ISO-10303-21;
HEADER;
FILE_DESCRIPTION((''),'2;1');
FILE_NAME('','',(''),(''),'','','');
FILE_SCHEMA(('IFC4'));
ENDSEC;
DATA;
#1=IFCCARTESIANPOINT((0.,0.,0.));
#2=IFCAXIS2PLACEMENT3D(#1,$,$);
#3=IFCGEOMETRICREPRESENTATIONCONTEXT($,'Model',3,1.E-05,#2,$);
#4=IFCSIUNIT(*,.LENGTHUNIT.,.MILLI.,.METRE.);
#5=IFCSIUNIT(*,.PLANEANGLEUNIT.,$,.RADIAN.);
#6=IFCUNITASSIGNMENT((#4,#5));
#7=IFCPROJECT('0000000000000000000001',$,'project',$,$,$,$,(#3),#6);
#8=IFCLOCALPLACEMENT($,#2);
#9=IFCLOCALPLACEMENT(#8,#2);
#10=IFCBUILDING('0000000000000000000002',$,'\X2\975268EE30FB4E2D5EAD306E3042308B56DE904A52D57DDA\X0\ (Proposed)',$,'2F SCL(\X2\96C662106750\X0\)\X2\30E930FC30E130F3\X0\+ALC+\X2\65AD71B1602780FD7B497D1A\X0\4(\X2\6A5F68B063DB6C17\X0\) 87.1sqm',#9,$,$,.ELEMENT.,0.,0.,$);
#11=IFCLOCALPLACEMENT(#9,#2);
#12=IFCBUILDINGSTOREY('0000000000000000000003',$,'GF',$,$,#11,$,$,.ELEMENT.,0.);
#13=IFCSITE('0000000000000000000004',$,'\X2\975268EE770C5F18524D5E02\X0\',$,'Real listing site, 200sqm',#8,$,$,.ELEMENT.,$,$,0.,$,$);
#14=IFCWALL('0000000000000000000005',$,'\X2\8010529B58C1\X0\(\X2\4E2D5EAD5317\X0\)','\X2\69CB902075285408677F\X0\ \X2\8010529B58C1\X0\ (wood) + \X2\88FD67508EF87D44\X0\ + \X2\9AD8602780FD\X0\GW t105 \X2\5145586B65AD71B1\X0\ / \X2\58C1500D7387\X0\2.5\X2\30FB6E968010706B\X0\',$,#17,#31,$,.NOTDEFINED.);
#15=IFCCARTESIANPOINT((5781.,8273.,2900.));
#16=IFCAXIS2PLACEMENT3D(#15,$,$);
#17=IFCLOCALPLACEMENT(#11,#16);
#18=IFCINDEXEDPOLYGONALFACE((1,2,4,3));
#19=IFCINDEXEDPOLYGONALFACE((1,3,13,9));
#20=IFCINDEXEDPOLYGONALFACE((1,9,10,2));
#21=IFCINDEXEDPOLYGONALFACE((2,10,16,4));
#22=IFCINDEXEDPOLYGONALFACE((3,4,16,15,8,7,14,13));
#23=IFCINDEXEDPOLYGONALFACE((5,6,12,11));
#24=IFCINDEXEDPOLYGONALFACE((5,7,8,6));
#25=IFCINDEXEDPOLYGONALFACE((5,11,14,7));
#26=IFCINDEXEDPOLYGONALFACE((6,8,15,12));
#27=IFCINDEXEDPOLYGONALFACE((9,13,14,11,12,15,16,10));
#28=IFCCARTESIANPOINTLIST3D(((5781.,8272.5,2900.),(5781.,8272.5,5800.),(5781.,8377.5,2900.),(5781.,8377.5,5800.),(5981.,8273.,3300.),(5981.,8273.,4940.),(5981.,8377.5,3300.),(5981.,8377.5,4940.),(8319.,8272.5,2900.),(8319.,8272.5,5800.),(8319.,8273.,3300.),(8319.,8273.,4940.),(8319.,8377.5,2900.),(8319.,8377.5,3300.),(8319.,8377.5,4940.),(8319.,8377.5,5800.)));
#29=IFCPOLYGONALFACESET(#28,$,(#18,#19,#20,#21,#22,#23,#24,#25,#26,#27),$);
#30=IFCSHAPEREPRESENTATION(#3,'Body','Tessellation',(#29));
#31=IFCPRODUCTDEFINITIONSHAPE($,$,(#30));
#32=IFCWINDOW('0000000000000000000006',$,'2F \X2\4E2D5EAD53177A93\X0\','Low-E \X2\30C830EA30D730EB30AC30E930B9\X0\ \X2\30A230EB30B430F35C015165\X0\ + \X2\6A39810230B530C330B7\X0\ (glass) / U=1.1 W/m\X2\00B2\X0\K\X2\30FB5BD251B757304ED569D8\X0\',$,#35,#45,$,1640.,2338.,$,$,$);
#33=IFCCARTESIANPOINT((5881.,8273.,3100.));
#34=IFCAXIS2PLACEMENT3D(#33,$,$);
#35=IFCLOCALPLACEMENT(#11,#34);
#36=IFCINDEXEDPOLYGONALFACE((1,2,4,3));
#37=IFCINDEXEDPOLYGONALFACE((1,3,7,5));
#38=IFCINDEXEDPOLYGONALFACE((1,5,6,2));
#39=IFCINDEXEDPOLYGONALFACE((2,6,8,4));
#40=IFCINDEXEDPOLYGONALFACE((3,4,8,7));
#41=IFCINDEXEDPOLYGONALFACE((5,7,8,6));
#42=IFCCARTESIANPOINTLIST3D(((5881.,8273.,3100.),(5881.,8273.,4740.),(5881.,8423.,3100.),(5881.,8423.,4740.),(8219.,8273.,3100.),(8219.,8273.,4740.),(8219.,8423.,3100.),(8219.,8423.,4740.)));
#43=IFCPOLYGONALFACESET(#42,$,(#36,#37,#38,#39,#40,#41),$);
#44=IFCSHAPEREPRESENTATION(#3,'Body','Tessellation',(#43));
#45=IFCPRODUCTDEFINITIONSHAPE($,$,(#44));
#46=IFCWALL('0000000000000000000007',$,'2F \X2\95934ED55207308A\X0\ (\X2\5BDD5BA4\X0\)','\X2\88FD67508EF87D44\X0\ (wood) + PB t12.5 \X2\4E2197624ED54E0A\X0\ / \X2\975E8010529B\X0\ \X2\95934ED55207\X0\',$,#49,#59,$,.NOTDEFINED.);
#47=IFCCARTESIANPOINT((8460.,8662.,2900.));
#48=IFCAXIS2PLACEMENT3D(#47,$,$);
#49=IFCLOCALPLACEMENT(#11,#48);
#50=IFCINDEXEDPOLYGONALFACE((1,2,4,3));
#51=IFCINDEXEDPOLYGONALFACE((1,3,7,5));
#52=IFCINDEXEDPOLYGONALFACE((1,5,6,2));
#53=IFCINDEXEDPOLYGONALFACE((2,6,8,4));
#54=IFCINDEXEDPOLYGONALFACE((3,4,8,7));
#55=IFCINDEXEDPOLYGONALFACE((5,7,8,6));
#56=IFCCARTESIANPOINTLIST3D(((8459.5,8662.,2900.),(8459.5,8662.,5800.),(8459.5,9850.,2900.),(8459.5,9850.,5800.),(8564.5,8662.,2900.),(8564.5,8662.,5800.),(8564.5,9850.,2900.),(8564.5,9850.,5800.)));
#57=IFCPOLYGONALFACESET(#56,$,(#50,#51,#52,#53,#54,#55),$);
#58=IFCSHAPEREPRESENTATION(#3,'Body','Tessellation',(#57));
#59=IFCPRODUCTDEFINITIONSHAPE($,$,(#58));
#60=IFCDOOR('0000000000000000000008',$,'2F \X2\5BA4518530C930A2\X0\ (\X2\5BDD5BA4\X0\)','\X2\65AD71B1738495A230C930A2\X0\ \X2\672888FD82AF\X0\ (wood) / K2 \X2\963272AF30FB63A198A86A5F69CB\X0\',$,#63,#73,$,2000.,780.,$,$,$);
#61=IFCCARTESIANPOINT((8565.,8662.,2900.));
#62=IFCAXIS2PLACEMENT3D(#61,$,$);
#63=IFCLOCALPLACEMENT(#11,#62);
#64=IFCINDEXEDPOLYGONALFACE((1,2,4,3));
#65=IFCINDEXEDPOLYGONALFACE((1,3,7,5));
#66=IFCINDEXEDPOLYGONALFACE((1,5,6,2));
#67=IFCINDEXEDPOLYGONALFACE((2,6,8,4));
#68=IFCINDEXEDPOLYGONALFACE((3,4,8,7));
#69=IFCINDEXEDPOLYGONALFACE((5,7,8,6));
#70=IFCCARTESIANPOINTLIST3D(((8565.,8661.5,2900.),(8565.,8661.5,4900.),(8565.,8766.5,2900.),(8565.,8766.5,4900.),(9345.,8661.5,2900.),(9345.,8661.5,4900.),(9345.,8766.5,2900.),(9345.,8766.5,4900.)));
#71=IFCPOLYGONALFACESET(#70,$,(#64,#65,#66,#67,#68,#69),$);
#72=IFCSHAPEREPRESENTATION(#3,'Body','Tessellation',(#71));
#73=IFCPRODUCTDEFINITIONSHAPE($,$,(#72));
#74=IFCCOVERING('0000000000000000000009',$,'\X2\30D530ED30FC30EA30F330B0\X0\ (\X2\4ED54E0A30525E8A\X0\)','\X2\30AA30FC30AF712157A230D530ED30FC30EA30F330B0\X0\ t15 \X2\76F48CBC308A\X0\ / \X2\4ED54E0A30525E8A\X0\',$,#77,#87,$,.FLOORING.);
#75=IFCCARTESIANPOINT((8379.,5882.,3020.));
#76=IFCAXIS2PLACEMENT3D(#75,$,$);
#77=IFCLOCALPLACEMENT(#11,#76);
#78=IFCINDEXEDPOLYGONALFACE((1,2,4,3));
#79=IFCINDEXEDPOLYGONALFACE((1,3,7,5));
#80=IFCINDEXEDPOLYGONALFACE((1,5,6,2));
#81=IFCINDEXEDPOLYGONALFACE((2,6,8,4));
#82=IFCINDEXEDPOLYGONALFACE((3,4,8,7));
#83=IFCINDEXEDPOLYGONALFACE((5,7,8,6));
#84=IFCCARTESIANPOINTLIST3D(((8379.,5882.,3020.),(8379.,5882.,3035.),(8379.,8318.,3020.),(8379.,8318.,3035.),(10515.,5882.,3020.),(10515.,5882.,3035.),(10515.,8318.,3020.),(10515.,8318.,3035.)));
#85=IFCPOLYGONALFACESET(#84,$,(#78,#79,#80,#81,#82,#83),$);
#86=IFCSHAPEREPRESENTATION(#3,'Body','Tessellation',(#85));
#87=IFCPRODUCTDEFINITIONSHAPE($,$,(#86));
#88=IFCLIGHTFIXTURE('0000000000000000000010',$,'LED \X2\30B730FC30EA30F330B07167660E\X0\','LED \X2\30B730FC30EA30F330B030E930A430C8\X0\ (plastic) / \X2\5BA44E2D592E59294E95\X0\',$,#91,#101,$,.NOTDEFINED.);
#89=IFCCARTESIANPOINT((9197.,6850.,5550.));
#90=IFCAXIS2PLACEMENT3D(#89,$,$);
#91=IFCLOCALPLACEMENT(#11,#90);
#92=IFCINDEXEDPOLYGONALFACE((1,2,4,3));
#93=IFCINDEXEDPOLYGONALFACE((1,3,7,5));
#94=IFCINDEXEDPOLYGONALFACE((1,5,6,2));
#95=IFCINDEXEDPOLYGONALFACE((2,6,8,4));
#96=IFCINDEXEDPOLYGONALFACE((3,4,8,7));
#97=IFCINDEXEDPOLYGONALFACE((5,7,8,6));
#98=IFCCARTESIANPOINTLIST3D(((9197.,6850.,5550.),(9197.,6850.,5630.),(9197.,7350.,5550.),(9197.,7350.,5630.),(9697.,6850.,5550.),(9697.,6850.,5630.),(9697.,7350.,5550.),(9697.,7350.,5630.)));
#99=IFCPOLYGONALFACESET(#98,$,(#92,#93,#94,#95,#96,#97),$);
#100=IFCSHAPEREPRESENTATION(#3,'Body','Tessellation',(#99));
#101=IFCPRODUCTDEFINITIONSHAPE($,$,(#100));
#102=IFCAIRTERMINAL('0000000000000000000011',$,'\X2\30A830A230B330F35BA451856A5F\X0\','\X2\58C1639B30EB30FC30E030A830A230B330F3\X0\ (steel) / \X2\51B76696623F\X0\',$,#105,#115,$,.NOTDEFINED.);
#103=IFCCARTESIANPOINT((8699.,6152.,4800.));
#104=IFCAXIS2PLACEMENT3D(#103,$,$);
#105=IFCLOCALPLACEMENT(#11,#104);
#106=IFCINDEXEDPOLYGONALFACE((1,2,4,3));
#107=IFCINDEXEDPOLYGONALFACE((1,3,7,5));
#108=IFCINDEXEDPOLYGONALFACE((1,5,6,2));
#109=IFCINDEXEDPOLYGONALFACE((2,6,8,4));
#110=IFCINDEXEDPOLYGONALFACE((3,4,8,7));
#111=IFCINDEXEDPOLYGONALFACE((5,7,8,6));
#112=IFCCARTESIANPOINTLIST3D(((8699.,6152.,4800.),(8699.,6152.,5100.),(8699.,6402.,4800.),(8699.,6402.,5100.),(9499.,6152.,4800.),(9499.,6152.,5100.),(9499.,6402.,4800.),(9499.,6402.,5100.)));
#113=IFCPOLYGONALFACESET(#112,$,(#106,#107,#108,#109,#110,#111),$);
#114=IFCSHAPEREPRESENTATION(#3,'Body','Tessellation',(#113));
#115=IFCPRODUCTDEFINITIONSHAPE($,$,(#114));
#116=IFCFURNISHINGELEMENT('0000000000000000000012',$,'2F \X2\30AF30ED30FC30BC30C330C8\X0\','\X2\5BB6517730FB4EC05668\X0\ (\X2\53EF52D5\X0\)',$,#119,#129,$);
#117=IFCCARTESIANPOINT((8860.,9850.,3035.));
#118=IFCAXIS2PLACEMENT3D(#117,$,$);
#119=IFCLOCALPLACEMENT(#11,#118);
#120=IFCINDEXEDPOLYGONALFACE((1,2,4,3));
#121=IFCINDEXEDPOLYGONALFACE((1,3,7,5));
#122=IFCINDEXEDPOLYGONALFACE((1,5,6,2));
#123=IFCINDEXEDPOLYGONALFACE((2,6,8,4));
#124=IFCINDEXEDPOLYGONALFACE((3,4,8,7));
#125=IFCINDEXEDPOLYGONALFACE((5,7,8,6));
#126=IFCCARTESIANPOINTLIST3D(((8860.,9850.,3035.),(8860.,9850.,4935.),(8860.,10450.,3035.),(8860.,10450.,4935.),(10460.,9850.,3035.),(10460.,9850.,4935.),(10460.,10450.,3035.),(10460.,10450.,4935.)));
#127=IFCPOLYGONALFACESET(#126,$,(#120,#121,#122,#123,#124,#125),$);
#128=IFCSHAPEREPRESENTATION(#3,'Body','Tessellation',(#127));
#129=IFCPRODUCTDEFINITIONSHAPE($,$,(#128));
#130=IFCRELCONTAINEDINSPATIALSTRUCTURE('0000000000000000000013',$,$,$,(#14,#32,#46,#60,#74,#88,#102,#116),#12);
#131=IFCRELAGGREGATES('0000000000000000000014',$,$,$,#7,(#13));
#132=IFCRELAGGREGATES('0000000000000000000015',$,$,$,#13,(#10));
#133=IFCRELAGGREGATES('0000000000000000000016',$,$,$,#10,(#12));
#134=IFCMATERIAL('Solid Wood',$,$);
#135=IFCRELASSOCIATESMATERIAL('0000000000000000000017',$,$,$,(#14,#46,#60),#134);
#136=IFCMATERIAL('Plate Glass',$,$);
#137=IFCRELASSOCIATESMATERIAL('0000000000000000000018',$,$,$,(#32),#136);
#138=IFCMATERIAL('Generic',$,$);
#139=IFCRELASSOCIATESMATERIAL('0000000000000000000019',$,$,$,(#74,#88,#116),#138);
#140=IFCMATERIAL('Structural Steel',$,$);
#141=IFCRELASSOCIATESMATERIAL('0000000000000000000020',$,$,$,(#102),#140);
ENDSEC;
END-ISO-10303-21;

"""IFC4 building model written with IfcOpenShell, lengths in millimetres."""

from ifc_helpers import new_model, si_unit, frame, frame_2d, origin, place, context, project, spatial, rectangle, extrude, material, element, fill, save


model = new_model("IFC4")

# Units and contexts
model_context = context("Model", 3, precision=1e-05, world=origin())
ifc_project = project(units=[si_unit("LENGTHUNIT", "METRE", prefix="MILLI"), si_unit("PLANEANGLEUNIT", "RADIAN")], contexts=[model_context])

# Site, building, storey
site_placement = place(None, origin())
site = spatial("IfcSite", under=ifc_project, at=site_placement, Name="青森県弘前市", ObjectType="Real listing site, 200sqm", CompositionType="ELEMENT", RefElevation=0.0)
building_placement = place(site_placement, origin())
building = spatial("IfcBuilding", under=site, at=building_placement, Name="青森・中庭のある回遊動線 (Proposed)", ObjectType="2F SCL(集成材)ラーメン+ALC+断熱性能等級4(機械換気) 87.1sqm", CompositionType="ELEMENT", ElevationOfRefHeight=0.0, ElevationOfTerrain=0.0)
storey_placement = place(building_placement, origin())
storey = spatial("IfcBuildingStorey", under=building, at=storey_placement, Name="GF", CompositionType="ELEMENT", Elevation=0.0)

# Shared definitions
ifc_material_1 = material(Name="Solid Wood")

# Wall, opening, window
wall_1_placement = place(storey_placement, frame((5781.0, 8273.0, 2900.0)))
wall_1 = element("IfcWall", 1, at=wall_1_placement, inside=storey, material=ifc_material_1, Name="耐力壁(中庭北)", Description="構造用合板 耐力壁 (wood) + 製材軸組 + 高性能GW t105 充填断熱 / 壁倍率2.5・準耐火", PredefinedType="NOTDEFINED", context=model_context, shape_type="SweptSolid", body=[
    extrude(rectangle(XDim=2538.0, YDim=105.0, at=frame_2d((1269.0, 52.0))), frame((5781.0, 8273.0, 2900.0)), (0.0, 0.0, 1.0), 2900.0),
])
opening_placement = place(storey_placement, frame((5881.0, 8273.0, 3100.0)))
opening = element("IfcOpeningElement", 2, at=opening_placement, cuts=wall_1, PredefinedType="NOTDEFINED", context=model_context, shape_type="SweptSolid", body=[
    extrude(rectangle(XDim=2338.0, YDim=150.0, at=frame_2d((1169.0, 75.0))), frame((5881.0, 8273.0, 3100.0)), (0.0, 0.0, 1.0), 1640.0),
])
ifc_material_2 = material(Name="Plate Glass")
window_placement = place(storey_placement, frame((5881.0, 8273.0, 3100.0)))
window = element("IfcWindow", 3, at=window_placement, inside=storey, material=ifc_material_2, Name="2F 中庭北窓", Description="Low-E トリプルガラス アルゴン封入 + 樹脂サッシ (glass) / U=1.1 W/m²K・寒冷地仕様", OverallHeight=1640.0, OverallWidth=2338.0, context=model_context, shape_type="SweptSolid", body=[
    extrude(rectangle(XDim=2338.0, YDim=150.0, at=frame_2d((1169.0, 75.0))), frame((5881.0, 8273.0, 3100.0)), (0.0, 0.0, 1.0), 1640.0),
])
fill(opening, window)

# Wall
wall_2_placement = place(storey_placement, frame((8460.0, 8662.0, 2900.0)))
element("IfcWall", 4, at=wall_2_placement, inside=storey, material=ifc_material_1, Name="2F 間仕切り (寝室)", Description="製材軸組 (wood) + PB t12.5 両面仕上 / 非耐力 間仕切", PredefinedType="NOTDEFINED", context=model_context, shape_type="SweptSolid", body=[
    extrude(rectangle(XDim=105.0, YDim=1188.0, at=frame_2d((52.0, 594.0))), frame((8460.0, 8662.0, 2900.0)), (0.0, 0.0, 1.0), 2900.0),
])

# Door
door_placement = place(storey_placement, frame((8565.0, 8662.0, 2900.0)))
element("IfcDoor", 5, at=door_placement, inside=storey, material=ifc_material_1, Name="2F 室内ドア (寝室)", Description="断熱玄関ドア 木製芯 (wood) / K2 防犯・採風機構", OverallHeight=2000.0, OverallWidth=780.0, context=model_context, shape_type="SweptSolid", body=[
    extrude(rectangle(XDim=780.0, YDim=105.0, at=frame_2d((390.0, 52.0))), frame((8565.0, 8662.0, 2900.0)), (0.0, 0.0, 1.0), 2000.0),
])

# Covering
ifc_material_3 = material(Name="Generic")
covering_placement = place(storey_placement, frame((8379.0, 5882.0, 3020.0)))
element("IfcCovering", 6, at=covering_placement, inside=storey, material=ifc_material_3, Name="フローリング (仕上げ床)", Description="オーク無垢フローリング t15 直貼り / 仕上げ床", PredefinedType="FLOORING", context=model_context, shape_type="SweptSolid", body=[
    extrude(rectangle(XDim=2136.0, YDim=2436.0, at=frame_2d((1068.0, 1218.0))), frame((8379.0, 5882.0, 3020.0)), (0.0, 0.0, 1.0), 15.0),
])

# Light fixture
light_fixture_placement = place(storey_placement, frame((9197.0, 6850.0, 5550.0)))
element("IfcLightFixture", 7, at=light_fixture_placement, inside=storey, material=ifc_material_3, Name="LED シーリング照明", Description="LED シーリングライト (plastic) / 室中央天井", PredefinedType="NOTDEFINED", context=model_context, shape_type="SweptSolid", body=[
    extrude(rectangle(XDim=500.0, YDim=500.0, at=frame_2d((250.0, 250.0))), frame((9197.0, 6850.0, 5550.0)), (0.0, 0.0, 1.0), 80.0),
])

# Air terminal
ifc_material_4 = material(Name="Structural Steel")
air_terminal_placement = place(storey_placement, frame((8699.0, 6152.0, 4800.0)))
element("IfcAirTerminal", 8, at=air_terminal_placement, inside=storey, material=ifc_material_4, Name="エアコン室内機", Description="壁掛ルームエアコン (steel) / 冷暖房", PredefinedType="NOTDEFINED", context=model_context, shape_type="SweptSolid", body=[
    extrude(rectangle(XDim=800.0, YDim=250.0, at=frame_2d((400.0, 125.0))), frame((8699.0, 6152.0, 4800.0)), (0.0, 0.0, 1.0), 300.0),
])

# Furnishing element
furnishing_placement = place(storey_placement, frame((8860.0, 9850.0, 3035.0)))
element("IfcFurnishingElement", 9, at=furnishing_placement, inside=storey, material=ifc_material_3, Name="2F クローゼット", Description="家具・什器 (可動)", context=model_context, shape_type="SweptSolid", body=[
    extrude(rectangle(XDim=1600.0, YDim=600.0, at=frame_2d((800.0, 300.0))), frame((8860.0, 9850.0, 3035.0)), (0.0, 0.0, 1.0), 1900.0),
])

save(model, "model.ifc")
